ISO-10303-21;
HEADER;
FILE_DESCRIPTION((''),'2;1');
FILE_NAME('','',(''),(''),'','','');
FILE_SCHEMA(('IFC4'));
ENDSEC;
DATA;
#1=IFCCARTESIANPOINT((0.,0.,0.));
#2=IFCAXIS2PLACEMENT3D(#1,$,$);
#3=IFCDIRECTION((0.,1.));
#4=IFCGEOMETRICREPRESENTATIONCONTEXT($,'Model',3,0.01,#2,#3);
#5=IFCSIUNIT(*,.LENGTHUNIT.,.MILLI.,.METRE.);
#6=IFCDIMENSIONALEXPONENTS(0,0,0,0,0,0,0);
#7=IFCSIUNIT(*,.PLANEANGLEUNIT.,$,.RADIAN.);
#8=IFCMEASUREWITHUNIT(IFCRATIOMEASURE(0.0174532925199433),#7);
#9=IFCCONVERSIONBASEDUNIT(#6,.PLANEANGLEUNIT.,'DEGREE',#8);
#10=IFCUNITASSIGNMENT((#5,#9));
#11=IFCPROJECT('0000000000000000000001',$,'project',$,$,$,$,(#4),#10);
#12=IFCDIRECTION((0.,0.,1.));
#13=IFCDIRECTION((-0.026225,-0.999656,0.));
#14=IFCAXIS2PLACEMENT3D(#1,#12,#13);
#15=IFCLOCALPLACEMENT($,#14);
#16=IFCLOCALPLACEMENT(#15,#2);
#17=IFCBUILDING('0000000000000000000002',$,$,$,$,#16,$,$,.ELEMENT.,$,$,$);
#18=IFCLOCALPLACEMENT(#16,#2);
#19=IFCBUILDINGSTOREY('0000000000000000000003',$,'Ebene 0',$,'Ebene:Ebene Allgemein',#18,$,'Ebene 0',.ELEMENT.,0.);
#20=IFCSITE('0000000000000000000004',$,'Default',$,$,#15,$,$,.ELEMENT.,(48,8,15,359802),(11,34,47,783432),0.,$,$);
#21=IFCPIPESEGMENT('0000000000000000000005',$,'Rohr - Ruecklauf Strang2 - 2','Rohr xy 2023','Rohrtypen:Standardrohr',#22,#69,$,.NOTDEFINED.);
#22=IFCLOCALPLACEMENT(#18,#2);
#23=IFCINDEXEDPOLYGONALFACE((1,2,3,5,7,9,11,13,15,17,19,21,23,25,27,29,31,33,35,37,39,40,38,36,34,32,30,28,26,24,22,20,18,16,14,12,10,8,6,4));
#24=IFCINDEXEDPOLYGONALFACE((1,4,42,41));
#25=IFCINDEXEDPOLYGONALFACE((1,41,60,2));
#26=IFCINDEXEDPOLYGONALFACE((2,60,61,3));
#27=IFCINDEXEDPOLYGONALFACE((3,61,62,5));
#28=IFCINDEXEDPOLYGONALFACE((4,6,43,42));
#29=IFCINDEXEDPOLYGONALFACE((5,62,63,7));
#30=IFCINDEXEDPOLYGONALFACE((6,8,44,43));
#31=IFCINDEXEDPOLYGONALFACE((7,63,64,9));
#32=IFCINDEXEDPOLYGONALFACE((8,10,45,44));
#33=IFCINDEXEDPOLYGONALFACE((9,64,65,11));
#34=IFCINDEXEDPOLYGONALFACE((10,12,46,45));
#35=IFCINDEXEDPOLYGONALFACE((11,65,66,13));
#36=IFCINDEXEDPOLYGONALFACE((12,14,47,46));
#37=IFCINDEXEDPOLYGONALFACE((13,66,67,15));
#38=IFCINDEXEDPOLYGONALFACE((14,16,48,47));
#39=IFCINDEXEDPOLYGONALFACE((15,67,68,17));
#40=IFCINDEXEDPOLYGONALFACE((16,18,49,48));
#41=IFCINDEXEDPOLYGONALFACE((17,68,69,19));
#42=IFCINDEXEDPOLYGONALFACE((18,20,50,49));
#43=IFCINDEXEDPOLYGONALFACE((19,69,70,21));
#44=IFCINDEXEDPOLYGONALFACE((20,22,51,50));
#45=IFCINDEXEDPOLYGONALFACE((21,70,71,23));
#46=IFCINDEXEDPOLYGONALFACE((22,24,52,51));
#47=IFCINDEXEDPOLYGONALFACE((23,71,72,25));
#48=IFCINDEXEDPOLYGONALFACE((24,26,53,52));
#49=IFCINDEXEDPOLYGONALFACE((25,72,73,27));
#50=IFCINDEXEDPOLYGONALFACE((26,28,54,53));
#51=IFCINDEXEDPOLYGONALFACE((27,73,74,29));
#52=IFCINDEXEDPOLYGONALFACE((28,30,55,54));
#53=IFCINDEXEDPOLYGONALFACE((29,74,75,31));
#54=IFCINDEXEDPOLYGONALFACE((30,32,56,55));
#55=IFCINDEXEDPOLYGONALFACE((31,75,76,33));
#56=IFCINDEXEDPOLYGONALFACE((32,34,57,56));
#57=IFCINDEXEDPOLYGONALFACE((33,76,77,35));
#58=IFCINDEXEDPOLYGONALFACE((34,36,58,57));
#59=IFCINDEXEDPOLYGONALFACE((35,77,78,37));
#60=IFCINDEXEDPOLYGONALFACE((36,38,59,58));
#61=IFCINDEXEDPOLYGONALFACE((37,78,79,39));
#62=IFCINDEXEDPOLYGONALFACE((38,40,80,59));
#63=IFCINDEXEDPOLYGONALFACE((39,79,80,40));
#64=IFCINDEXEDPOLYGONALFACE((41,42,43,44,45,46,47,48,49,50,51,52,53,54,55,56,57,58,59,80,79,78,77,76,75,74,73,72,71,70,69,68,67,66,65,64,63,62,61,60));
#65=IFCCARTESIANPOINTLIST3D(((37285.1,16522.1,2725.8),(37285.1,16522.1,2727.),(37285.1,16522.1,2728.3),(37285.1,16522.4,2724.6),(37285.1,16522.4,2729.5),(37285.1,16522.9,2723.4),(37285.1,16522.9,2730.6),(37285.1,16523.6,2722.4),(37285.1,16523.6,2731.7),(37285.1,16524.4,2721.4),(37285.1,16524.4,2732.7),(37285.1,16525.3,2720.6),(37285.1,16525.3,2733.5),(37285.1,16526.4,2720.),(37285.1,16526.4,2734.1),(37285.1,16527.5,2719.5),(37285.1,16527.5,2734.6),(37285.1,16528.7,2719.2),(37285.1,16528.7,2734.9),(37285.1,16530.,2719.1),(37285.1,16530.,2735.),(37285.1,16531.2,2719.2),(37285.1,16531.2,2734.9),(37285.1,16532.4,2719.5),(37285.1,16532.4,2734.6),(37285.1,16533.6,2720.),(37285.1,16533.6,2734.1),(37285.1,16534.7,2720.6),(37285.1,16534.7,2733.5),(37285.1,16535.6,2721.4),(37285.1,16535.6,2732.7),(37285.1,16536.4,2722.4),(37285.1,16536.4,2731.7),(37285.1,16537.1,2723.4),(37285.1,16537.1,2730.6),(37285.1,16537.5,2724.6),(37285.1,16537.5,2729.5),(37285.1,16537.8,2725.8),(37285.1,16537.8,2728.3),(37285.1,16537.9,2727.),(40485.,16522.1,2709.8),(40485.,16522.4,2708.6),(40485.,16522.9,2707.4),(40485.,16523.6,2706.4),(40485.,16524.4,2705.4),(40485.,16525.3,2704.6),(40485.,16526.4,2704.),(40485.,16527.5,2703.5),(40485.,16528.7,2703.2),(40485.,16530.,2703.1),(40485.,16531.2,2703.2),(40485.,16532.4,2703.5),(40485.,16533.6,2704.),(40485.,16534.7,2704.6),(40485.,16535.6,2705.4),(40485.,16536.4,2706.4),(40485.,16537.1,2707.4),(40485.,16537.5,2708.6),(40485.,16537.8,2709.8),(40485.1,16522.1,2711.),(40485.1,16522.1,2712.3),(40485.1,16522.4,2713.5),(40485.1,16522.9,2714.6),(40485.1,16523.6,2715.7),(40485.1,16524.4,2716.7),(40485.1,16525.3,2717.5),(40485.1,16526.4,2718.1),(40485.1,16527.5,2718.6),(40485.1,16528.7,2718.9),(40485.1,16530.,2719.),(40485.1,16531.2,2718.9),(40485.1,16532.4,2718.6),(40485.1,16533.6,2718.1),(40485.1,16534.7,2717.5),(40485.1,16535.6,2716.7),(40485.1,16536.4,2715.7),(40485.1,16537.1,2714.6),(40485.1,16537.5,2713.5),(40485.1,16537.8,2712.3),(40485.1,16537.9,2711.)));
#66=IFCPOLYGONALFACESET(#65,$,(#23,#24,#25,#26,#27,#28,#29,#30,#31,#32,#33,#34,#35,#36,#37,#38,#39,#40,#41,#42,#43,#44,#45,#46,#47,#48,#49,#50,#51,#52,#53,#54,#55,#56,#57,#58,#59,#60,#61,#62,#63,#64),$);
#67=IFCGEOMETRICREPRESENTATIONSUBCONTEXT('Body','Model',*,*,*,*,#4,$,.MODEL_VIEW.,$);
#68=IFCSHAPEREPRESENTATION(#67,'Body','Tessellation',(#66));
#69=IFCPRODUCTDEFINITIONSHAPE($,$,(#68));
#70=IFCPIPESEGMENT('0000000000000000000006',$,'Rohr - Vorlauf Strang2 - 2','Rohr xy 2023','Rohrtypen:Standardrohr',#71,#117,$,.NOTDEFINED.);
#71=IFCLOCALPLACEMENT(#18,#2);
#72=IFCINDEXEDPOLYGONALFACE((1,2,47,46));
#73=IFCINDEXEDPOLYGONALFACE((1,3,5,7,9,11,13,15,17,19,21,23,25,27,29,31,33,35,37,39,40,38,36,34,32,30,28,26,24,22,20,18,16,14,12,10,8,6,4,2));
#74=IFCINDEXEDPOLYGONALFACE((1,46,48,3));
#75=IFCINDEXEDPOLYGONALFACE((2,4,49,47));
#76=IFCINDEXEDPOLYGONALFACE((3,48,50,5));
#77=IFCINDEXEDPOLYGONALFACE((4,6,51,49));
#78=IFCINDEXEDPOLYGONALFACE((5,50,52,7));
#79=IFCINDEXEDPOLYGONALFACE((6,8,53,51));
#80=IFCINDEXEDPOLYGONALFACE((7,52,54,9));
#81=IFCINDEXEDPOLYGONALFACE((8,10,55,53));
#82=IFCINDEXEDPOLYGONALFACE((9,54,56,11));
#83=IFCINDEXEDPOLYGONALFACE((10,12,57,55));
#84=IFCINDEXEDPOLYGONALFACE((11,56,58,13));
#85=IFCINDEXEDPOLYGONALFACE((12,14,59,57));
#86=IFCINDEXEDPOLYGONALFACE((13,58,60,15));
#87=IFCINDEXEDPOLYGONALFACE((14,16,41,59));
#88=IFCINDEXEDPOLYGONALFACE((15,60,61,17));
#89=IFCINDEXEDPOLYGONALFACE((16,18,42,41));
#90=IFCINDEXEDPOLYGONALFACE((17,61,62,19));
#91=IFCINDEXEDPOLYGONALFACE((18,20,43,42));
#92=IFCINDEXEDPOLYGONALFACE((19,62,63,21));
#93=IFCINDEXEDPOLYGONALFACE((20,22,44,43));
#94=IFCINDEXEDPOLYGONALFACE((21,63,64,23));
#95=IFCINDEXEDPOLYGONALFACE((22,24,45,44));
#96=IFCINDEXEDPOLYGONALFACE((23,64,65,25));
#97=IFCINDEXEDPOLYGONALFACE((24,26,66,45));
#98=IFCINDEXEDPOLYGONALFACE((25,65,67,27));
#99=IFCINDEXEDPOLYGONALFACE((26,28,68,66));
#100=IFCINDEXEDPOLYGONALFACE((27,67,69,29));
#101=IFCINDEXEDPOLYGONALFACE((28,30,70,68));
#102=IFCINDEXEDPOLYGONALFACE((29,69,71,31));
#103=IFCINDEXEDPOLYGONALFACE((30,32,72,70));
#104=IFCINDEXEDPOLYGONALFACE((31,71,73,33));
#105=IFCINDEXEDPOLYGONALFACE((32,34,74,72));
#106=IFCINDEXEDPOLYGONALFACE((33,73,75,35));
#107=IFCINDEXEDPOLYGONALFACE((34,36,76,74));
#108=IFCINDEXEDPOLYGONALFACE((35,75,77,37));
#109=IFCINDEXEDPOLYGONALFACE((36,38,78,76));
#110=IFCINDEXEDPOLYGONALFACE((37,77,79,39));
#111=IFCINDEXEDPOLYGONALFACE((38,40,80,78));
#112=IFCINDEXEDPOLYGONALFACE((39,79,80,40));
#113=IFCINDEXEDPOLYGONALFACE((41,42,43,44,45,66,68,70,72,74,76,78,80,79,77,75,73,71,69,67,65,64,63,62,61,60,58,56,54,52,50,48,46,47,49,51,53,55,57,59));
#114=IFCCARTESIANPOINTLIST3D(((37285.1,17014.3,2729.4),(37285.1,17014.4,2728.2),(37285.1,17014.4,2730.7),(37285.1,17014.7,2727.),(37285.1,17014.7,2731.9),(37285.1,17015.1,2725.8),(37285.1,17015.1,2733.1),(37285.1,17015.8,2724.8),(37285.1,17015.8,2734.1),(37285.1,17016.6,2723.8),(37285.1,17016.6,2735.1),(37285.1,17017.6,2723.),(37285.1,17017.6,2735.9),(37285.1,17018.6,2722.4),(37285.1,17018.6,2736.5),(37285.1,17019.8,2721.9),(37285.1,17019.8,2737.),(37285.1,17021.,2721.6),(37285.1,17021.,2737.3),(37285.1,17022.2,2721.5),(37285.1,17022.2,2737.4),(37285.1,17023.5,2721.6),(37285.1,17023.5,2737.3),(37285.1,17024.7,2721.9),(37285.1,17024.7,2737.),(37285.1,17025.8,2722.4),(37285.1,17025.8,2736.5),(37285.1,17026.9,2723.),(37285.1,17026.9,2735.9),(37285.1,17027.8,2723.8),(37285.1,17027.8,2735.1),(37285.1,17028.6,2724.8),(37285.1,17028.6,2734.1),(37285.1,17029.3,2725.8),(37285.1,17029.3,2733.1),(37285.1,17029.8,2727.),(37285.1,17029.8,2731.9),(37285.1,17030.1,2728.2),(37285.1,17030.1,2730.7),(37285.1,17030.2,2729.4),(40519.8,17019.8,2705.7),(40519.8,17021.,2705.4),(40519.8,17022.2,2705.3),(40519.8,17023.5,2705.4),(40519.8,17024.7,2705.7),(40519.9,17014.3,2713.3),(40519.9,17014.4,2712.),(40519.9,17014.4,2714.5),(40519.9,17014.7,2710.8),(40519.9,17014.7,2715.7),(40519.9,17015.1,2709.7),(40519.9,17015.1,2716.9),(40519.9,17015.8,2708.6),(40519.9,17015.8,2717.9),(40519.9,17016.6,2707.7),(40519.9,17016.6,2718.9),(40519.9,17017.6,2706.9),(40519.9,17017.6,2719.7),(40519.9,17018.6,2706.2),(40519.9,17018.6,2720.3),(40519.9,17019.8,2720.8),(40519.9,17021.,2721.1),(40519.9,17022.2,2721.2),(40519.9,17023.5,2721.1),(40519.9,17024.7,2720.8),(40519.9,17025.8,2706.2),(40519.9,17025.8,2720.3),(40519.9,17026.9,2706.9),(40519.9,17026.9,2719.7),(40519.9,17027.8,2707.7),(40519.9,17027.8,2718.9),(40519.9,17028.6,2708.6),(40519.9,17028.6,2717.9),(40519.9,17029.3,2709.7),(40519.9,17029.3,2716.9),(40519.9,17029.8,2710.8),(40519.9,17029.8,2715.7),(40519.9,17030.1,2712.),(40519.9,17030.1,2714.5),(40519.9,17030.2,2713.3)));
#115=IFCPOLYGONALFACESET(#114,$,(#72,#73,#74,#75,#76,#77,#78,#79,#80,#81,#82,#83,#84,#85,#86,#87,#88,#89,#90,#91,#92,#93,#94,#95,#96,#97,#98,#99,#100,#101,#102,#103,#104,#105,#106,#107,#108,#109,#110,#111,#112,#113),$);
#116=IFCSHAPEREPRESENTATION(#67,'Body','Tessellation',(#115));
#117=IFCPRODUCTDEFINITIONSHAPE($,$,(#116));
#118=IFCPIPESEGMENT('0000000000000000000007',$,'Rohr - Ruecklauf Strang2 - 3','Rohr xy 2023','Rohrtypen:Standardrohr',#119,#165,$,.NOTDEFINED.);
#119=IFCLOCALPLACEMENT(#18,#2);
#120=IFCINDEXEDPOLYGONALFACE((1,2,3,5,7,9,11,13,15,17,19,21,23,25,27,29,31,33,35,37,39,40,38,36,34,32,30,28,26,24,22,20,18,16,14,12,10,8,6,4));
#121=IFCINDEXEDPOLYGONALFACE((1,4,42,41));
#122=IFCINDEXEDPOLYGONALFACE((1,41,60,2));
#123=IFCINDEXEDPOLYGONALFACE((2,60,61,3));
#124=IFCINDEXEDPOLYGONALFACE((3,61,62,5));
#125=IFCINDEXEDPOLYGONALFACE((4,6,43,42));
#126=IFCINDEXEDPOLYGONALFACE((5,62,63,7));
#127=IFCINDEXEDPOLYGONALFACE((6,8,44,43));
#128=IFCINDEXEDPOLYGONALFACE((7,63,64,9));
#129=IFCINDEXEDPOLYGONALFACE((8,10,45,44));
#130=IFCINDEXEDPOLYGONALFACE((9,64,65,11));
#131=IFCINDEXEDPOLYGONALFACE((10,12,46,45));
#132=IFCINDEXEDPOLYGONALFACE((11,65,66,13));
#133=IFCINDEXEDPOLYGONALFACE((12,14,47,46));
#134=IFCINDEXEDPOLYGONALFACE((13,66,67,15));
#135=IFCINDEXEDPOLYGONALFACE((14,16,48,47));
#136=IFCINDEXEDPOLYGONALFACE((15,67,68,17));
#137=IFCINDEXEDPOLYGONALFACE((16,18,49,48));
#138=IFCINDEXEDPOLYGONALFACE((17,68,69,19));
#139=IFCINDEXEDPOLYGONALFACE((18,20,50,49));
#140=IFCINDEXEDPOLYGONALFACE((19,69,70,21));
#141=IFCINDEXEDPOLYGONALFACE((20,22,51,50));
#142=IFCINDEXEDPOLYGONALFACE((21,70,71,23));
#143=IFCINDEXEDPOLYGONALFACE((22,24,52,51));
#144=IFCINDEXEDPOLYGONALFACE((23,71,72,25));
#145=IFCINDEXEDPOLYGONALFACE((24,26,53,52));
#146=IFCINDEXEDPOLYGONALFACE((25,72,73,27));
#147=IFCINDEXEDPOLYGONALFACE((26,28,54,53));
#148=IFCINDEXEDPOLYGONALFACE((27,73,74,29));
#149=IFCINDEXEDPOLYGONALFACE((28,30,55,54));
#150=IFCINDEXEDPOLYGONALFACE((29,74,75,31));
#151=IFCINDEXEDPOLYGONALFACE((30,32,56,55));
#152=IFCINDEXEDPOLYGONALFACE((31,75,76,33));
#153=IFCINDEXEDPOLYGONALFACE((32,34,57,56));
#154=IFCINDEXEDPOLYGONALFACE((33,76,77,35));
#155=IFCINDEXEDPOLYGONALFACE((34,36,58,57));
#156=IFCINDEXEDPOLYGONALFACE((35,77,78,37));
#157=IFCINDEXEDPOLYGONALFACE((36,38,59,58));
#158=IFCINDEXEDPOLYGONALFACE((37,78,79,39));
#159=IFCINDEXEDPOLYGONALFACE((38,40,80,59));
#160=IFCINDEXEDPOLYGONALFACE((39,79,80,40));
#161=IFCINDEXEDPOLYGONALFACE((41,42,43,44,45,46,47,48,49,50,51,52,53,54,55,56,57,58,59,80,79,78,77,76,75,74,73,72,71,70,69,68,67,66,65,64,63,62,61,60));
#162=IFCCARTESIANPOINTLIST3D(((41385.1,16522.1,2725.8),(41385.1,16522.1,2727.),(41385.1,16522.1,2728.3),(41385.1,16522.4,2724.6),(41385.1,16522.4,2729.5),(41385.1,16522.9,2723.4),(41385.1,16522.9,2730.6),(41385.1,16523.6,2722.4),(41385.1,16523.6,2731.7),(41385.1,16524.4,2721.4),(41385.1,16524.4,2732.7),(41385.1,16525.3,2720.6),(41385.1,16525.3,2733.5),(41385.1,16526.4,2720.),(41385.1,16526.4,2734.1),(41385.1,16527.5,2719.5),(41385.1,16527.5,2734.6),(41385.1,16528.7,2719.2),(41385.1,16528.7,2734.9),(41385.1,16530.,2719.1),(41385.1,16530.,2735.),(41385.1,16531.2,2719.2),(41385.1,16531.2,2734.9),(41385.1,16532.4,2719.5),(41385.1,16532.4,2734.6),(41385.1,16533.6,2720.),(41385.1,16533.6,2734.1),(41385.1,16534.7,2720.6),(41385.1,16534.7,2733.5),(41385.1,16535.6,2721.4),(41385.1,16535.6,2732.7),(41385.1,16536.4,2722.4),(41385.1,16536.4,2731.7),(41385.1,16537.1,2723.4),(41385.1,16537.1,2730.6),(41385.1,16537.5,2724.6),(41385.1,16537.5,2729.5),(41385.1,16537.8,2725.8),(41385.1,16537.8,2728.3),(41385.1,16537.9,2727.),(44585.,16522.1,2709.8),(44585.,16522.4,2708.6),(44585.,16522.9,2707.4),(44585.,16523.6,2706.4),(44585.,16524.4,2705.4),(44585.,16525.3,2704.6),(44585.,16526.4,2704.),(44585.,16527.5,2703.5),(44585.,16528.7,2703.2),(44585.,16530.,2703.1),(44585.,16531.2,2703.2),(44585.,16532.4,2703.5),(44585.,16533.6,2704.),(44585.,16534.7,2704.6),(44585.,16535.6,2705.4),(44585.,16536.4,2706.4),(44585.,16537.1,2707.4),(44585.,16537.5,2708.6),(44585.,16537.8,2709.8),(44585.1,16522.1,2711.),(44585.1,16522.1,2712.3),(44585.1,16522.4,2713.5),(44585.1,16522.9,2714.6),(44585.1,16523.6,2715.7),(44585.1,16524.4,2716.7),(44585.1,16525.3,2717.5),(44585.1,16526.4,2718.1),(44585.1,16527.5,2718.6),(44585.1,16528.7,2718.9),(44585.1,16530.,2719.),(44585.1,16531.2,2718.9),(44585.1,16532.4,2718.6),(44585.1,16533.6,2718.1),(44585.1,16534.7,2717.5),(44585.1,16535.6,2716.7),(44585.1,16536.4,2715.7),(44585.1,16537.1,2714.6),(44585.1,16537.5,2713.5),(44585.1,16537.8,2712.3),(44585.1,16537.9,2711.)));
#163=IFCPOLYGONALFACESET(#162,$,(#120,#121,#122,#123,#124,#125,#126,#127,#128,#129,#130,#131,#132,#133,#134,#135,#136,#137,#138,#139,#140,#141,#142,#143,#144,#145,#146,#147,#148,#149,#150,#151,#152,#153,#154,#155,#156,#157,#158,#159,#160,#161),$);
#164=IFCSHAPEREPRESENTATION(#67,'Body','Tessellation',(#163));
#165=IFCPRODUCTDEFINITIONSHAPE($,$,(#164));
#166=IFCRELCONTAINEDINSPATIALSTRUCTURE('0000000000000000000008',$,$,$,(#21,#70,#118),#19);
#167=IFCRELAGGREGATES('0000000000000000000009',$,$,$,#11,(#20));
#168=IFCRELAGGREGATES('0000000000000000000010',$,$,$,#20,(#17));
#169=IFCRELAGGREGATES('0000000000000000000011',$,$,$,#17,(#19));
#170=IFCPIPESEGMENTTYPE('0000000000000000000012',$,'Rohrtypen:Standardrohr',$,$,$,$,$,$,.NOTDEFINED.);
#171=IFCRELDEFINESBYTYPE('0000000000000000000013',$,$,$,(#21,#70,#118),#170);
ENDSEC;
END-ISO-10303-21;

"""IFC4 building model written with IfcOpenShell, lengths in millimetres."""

from ifc_helpers import new_model, entity, si_unit, converted_unit, direction, frame, origin, place, context, subcontext, project, spatial, indexed_curve, outline, extrude, type_object, element, save


model = new_model("IFC4")

# Units and contexts
model_context = context("Model", 3, precision=0.01, world=origin(), true_north=direction((0.0, 1.0)))
body_context = subcontext(model_context, "Body", "Model", "MODEL_VIEW")
ifc_project = project(units=[si_unit("LENGTHUNIT", "METRE", prefix="MILLI"), converted_unit("PLANEANGLEUNIT", "DEGREE", entity("IfcRatioMeasure", 0.0174532925199433), si_unit("PLANEANGLEUNIT", "RADIAN"), dimensions=[0, 0, 0, 0, 0, 0, 0])], contexts=[model_context])

# Site, building, storey
site_placement = place(None, frame((0.0, 0.0, 0.0), z_axis=(0.0, 0.0, 1.0), x_axis=(-0.026225, -0.999656, 0.0)))
site = spatial("IfcSite", under=ifc_project, at=site_placement, Name="Default", CompositionType="ELEMENT", RefLatitude=(48, 8, 15, 359802), RefLongitude=(11, 34, 47, 783432), RefElevation=0.0)
building_placement = place(site_placement, origin())
building = spatial("IfcBuilding", under=site, at=building_placement, CompositionType="ELEMENT")
storey_placement = place(building_placement, origin())
storey = spatial("IfcBuildingStorey", under=building, at=storey_placement, Name="Ebene 0", ObjectType="Ebene:Ebene Allgemein", LongName="Ebene 0", CompositionType="ELEMENT", Elevation=0.0)

# Pipe segments
pipe_segment_type = type_object("IfcPipeSegmentType", Name="Rohrtypen:Standardrohr", PredefinedType="NOTDEFINED")
pipe_segment_1_placement = place(storey_placement, origin())
element("IfcPipeSegment", 1, at=pipe_segment_1_placement, inside=storey, type_object=pipe_segment_type, Name="Rohr - Ruecklauf Strang2 - 2", Description="Rohr xy 2023", ObjectType="Rohrtypen:Standardrohr", PredefinedType="NOTDEFINED", context=body_context, shape_type="SweptSolid", body=[
    extrude(outline(indexed_curve([(7.9, 0.0), (7.8, 1.2), (7.6, 2.5), (7.1, 3.6), (6.4, 4.7), (5.6, 5.6), (4.7, 6.4), (3.6, 7.1), (2.5, 7.6), (1.2, 7.8), (0.0, 7.9), (-1.2, 7.8), (-2.5, 7.6), (-3.6, 7.1), (-4.7, 6.4), (-5.6, 5.6), (-6.4, 4.7), (-7.1, 3.6), (-7.6, 2.5), (-7.8, 1.2), (-7.9, 0.0), (-7.8, -1.2), (-7.6, -2.5), (-7.1, -3.6), (-6.4, -4.7), (-5.6, -5.6), (-4.7, -6.4), (-3.6, -7.1), (-2.5, -7.6), (-1.2, -7.8), (0.0, -7.9), (1.2, -7.8), (2.5, -7.6), (3.6, -7.1), (4.7, -6.4), (5.6, -5.6), (6.4, -4.7), (7.1, -3.6), (7.6, -2.5), (7.8, -1.2), (7.9, 0.0)], self_intersect=False)), frame((40485.1, 16530.0, 2711.0), z_axis=(-0.999988, 0.0, 0.005), x_axis=(0.0, 1.0, 0.0)), (0.0, 0.0, 1.0), 3200.0),
])
pipe_segment_2_placement = place(storey_placement, origin())
element("IfcPipeSegment", 2, at=pipe_segment_2_placement, inside=storey, type_object=pipe_segment_type, Name="Rohr - Vorlauf Strang2 - 2", Description="Rohr xy 2023", ObjectType="Rohrtypen:Standardrohr", PredefinedType="NOTDEFINED", context=body_context, shape_type="SweptSolid", body=[
    extrude(outline(indexed_curve([(7.9, 0.0), (7.8, 1.2), (7.6, 2.5), (7.1, 3.6), (6.4, 4.7), (5.6, 5.6), (4.7, 6.4), (3.6, 7.1), (2.5, 7.6), (1.2, 7.8), (0.0, 7.9), (-1.2, 7.8), (-2.5, 7.6), (-3.6, 7.1), (-4.7, 6.4), (-5.6, 5.6), (-6.4, 4.7), (-7.1, 3.6), (-7.6, 2.5), (-7.8, 1.2), (-7.9, 0.0), (-7.8, -1.2), (-7.6, -2.5), (-7.1, -3.6), (-6.4, -4.7), (-5.6, -5.6), (-4.7, -6.4), (-3.6, -7.1), (-2.5, -7.6), (-1.2, -7.8), (0.0, -7.9), (1.2, -7.8), (2.5, -7.6), (3.6, -7.1), (4.7, -6.4), (5.6, -5.6), (6.4, -4.7), (7.1, -3.6), (7.6, -2.5), (7.8, -1.2), (7.9, 0.0)], self_intersect=False)), frame((40519.9, 17022.2, 2713.3), z_axis=(-0.999988, 0.0, 0.005), x_axis=(0.0, 1.0, 0.0)), (0.0, 0.0, 1.0), 3234.8),
])
pipe_segment_3_placement = place(storey_placement, origin())
element("IfcPipeSegment", 3, at=pipe_segment_3_placement, inside=storey, type_object=pipe_segment_type, Name="Rohr - Ruecklauf Strang2 - 3", Description="Rohr xy 2023", ObjectType="Rohrtypen:Standardrohr", PredefinedType="NOTDEFINED", context=body_context, shape_type="SweptSolid", body=[
    extrude(outline(indexed_curve([(7.9, 0.0), (7.8, 1.2), (7.6, 2.5), (7.1, 3.6), (6.4, 4.7), (5.6, 5.6), (4.7, 6.4), (3.6, 7.1), (2.5, 7.6), (1.2, 7.8), (0.0, 7.9), (-1.2, 7.8), (-2.5, 7.6), (-3.6, 7.1), (-4.7, 6.4), (-5.6, 5.6), (-6.4, 4.7), (-7.1, 3.6), (-7.6, 2.5), (-7.8, 1.2), (-7.9, 0.0), (-7.8, -1.2), (-7.6, -2.5), (-7.1, -3.6), (-6.4, -4.7), (-5.6, -5.6), (-4.7, -6.4), (-3.6, -7.1), (-2.5, -7.6), (-1.2, -7.8), (0.0, -7.9), (1.2, -7.8), (2.5, -7.6), (3.6, -7.1), (4.7, -6.4), (5.6, -5.6), (6.4, -4.7), (7.1, -3.6), (7.6, -2.5), (7.8, -1.2), (7.9, 0.0)], self_intersect=False)), frame((44585.1, 16530.0, 2711.0), z_axis=(-0.999988, 0.0, 0.005), x_axis=(0.0, 1.0, 0.0)), (0.0, 0.0, 1.0), 3200.0),
])

save(model, "model.ifc")
